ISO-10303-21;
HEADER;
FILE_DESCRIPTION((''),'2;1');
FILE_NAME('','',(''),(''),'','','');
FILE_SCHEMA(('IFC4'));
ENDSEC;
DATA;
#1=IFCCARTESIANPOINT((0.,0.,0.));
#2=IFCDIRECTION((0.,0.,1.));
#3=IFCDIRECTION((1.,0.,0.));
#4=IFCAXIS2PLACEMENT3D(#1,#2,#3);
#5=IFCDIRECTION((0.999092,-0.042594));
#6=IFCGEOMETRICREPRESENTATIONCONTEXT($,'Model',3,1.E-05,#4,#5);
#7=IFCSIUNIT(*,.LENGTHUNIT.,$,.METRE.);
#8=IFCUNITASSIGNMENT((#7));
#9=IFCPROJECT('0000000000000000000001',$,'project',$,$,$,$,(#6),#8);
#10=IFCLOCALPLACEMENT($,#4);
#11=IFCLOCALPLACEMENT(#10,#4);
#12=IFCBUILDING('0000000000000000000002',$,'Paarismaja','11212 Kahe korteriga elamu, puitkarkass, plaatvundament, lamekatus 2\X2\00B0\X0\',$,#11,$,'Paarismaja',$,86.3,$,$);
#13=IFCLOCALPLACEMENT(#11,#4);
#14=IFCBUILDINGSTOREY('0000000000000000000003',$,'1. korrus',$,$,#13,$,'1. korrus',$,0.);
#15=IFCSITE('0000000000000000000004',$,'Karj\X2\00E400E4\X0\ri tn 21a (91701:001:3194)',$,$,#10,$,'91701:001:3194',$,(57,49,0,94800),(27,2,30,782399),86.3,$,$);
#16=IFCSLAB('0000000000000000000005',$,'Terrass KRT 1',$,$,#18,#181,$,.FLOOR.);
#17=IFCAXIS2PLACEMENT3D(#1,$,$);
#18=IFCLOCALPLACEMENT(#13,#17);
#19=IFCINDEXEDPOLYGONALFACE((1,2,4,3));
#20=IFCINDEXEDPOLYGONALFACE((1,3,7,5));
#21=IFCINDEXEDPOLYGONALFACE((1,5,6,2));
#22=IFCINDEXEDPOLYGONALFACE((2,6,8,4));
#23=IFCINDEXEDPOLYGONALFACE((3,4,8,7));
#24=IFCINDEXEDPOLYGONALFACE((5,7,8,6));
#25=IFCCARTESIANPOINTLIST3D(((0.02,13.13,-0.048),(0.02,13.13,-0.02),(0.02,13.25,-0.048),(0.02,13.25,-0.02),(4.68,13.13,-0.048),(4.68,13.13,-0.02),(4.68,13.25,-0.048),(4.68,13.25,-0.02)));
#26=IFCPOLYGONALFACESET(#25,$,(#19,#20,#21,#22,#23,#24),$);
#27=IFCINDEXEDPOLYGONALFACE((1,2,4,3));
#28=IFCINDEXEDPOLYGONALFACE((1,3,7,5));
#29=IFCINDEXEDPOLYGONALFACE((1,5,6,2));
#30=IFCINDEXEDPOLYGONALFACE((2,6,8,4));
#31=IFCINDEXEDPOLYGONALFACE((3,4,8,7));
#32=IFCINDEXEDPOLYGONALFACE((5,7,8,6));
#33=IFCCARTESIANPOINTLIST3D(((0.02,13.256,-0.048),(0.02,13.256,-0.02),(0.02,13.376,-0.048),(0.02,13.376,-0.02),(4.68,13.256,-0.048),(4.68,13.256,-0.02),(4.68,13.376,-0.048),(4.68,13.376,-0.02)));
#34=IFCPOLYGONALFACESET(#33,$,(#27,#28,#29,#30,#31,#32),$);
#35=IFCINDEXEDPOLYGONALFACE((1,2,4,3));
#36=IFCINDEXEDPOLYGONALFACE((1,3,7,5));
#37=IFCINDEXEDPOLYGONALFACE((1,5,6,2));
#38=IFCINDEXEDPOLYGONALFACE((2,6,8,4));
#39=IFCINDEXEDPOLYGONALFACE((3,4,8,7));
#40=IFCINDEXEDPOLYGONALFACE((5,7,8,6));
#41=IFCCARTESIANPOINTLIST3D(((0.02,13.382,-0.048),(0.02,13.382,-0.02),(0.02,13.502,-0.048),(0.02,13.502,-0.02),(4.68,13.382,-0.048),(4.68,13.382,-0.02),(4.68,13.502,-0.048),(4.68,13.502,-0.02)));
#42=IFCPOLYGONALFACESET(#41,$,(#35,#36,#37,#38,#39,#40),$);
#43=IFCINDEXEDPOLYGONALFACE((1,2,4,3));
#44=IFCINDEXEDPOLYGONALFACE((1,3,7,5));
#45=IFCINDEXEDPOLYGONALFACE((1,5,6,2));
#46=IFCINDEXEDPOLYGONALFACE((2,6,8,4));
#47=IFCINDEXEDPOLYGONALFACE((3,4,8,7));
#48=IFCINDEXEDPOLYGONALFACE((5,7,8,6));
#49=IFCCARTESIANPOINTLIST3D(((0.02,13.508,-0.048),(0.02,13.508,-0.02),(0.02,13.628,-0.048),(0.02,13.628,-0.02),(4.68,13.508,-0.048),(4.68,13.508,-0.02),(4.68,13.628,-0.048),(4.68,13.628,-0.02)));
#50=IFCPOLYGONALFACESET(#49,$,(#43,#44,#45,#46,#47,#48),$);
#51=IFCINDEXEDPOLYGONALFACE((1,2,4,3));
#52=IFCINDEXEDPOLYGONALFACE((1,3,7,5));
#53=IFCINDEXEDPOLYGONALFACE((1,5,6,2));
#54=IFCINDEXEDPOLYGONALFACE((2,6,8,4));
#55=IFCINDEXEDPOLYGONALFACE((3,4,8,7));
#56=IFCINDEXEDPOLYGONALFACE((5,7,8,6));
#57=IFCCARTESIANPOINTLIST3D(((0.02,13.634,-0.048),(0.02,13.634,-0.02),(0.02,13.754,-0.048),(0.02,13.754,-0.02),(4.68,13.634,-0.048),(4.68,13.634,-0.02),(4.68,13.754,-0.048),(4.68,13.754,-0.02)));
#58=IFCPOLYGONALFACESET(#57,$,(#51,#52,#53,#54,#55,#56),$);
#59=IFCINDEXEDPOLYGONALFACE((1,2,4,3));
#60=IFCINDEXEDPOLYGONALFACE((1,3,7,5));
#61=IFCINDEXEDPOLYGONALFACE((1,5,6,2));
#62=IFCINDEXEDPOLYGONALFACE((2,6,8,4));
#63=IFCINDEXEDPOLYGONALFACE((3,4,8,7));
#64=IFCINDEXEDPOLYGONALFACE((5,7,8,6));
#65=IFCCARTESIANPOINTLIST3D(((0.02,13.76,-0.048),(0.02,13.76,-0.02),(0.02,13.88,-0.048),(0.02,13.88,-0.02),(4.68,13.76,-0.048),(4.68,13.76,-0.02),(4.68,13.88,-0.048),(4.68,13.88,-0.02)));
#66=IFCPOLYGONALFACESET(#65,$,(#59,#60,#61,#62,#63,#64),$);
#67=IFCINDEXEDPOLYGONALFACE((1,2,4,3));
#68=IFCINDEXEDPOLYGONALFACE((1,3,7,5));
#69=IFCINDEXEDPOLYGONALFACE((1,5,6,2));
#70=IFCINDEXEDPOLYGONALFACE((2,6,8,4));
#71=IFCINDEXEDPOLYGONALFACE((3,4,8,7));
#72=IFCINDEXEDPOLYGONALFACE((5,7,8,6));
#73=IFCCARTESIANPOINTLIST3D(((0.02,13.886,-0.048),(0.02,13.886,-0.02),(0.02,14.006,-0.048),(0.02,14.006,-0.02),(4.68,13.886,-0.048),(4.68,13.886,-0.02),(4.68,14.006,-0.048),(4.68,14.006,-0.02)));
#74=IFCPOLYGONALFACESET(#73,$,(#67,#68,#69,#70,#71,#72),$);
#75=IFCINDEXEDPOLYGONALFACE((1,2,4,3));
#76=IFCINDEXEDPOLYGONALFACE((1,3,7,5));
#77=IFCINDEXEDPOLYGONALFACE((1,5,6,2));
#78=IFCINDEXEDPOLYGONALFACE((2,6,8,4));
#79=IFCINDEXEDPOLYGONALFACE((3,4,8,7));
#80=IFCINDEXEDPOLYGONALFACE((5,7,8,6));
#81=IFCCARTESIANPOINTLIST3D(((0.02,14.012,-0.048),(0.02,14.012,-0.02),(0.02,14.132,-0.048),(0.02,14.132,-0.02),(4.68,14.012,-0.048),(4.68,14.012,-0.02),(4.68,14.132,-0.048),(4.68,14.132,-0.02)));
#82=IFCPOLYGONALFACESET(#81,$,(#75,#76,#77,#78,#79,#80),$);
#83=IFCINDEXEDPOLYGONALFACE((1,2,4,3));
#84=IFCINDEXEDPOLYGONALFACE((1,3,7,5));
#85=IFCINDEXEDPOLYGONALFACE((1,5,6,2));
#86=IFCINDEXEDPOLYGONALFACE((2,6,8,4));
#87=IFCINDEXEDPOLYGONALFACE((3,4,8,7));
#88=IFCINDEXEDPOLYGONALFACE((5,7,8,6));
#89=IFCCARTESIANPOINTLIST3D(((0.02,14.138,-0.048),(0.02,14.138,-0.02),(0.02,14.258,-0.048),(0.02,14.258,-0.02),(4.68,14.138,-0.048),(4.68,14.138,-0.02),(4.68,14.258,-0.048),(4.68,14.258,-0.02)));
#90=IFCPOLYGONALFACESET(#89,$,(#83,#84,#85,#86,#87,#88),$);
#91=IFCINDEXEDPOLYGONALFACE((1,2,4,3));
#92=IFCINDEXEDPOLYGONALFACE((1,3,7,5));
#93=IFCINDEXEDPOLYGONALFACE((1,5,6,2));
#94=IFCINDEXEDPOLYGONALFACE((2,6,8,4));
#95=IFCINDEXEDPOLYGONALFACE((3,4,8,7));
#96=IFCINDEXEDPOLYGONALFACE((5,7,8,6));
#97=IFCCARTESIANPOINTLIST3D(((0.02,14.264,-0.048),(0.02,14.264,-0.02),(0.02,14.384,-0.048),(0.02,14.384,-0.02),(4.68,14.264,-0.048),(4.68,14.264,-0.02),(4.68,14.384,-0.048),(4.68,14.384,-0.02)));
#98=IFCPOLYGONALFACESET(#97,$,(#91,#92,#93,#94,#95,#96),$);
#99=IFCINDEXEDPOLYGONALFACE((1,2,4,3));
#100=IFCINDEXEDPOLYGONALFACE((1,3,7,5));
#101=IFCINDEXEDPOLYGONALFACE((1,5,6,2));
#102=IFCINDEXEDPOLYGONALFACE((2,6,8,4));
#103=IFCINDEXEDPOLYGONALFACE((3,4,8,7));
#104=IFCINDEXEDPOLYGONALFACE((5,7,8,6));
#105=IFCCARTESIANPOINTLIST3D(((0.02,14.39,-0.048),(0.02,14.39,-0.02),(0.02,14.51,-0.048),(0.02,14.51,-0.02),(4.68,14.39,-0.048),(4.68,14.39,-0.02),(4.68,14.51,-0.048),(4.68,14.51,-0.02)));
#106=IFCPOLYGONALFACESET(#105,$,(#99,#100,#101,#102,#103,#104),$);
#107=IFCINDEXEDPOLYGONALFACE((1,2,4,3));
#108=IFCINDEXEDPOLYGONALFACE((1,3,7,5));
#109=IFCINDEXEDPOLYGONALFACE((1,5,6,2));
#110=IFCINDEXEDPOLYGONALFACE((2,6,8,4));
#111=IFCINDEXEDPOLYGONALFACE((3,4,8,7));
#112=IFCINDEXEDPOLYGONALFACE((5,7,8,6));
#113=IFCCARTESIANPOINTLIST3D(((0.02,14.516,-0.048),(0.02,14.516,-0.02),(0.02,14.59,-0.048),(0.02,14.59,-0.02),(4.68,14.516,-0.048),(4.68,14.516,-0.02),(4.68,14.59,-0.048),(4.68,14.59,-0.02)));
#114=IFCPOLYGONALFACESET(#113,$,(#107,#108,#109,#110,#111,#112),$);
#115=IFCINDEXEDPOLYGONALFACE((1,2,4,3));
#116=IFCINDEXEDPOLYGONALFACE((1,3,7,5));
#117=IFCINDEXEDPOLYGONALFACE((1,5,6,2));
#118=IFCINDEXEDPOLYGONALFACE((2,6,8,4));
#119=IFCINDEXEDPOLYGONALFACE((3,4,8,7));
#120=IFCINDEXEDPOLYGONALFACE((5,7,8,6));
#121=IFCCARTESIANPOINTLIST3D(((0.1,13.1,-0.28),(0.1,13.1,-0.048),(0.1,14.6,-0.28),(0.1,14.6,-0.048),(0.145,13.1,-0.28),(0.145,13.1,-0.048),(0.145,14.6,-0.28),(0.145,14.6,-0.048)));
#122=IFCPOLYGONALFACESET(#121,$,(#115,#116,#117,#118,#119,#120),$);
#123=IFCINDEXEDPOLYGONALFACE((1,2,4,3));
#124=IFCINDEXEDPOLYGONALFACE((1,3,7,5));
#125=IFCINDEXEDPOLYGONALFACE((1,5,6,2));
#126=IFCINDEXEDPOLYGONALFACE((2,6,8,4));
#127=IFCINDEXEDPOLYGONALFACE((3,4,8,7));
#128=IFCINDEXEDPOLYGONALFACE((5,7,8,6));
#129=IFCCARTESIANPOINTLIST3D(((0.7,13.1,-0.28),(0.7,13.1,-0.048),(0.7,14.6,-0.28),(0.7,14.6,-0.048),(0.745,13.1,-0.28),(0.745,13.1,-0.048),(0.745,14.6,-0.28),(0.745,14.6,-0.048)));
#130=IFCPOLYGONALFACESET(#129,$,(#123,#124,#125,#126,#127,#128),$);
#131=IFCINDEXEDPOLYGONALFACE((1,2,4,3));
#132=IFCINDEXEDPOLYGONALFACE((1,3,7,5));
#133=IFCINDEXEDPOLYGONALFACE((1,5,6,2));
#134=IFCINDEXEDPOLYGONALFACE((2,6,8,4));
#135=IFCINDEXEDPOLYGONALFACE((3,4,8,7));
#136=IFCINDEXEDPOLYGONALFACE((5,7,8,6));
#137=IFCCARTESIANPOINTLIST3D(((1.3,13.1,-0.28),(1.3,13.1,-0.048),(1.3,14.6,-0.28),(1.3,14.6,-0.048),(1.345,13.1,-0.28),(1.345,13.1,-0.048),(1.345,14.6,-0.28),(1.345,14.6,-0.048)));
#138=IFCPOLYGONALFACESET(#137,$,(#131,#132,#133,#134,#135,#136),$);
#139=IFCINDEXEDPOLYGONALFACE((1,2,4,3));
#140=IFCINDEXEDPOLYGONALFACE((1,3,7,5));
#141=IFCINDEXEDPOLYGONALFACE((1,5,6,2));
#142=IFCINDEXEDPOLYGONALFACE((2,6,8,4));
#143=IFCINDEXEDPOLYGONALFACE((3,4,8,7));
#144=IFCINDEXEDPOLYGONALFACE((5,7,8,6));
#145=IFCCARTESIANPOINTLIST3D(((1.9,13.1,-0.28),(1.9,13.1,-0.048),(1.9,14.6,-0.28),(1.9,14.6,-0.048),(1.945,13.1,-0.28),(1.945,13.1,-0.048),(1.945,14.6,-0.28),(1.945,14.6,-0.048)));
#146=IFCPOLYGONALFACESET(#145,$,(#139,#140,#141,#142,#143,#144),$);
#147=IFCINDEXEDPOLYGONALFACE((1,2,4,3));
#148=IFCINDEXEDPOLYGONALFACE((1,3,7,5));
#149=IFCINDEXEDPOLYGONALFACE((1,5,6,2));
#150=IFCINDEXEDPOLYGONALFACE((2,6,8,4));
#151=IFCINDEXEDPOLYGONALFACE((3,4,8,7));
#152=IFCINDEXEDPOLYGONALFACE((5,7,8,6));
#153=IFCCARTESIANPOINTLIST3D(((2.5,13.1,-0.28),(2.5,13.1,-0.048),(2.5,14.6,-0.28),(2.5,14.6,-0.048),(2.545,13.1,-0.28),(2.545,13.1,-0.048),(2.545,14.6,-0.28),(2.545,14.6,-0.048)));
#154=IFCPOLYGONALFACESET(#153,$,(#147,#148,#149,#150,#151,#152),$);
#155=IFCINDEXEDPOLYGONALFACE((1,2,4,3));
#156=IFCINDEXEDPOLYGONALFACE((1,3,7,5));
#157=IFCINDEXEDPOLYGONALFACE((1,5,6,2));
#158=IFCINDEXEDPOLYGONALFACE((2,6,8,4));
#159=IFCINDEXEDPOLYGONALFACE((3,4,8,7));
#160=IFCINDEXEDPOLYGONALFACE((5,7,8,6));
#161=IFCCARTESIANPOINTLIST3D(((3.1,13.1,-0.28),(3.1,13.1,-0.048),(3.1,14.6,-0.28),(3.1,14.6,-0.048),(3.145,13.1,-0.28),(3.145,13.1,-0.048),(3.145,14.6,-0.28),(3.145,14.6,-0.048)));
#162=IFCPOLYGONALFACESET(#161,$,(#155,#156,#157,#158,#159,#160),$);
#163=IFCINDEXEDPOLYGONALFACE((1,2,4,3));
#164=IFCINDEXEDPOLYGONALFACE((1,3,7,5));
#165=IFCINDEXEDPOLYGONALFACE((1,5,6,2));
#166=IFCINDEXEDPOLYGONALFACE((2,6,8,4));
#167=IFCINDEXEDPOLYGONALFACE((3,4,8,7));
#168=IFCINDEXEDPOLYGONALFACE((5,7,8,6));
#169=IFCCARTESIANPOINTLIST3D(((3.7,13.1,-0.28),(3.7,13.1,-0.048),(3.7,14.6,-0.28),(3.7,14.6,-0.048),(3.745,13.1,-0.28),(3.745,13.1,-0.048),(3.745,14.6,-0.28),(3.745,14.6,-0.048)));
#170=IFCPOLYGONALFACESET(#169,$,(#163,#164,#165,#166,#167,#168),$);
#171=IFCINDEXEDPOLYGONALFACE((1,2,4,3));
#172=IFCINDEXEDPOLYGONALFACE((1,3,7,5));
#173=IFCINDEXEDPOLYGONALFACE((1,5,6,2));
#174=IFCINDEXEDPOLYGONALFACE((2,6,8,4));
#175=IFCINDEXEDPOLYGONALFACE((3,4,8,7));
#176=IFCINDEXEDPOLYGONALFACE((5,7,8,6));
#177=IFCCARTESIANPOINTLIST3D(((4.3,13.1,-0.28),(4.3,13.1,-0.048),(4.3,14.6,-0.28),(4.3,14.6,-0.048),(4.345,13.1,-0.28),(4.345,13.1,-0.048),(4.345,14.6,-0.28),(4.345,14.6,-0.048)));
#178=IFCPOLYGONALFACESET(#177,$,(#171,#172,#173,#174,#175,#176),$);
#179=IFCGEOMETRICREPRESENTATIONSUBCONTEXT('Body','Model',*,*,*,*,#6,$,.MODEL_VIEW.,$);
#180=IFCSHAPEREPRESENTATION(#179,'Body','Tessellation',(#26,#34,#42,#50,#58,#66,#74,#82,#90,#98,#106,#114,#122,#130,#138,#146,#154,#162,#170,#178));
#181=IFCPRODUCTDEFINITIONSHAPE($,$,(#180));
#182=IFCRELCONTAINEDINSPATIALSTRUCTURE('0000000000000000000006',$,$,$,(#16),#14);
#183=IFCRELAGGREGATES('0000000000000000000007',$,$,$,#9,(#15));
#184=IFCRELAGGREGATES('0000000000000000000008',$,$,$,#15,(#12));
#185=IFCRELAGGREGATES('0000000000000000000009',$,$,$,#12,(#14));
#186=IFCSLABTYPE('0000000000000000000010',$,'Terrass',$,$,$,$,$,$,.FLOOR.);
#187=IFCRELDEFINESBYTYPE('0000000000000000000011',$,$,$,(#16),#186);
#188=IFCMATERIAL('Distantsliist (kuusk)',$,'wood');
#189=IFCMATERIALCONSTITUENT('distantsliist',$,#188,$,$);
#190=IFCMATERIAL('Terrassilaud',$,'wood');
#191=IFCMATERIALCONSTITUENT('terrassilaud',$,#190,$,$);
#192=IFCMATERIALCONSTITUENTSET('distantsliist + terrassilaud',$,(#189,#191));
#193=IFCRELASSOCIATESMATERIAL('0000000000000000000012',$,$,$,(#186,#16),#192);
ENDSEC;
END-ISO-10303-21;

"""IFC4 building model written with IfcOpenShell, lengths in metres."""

from ifc_helpers import new_model, si_unit, direction, frame, origin_with_axes, place, context, subcontext, project, spatial, indexed_curve, outline, extrude, material, constituent, constituent_set, type_object, element, save


model = new_model("IFC4")

# Units and contexts
model_context = context("Model", 3, precision=1e-05, world=origin_with_axes(), true_north=direction((0.999092, -0.042594)))
body_context = subcontext(model_context, "Body", "Model", "MODEL_VIEW")
ifc_project = project(units=[si_unit("LENGTHUNIT", "METRE")], contexts=[model_context])

# Site, building, storey
site_placement = place(None, origin_with_axes())
site = spatial("IfcSite", under=ifc_project, at=site_placement, Name="Karjääri tn 21a (91701:001:3194)", LongName="91701:001:3194", RefLatitude=(57, 49, 0, 94800), RefLongitude=(27, 2, 30, 782399), RefElevation=86.3)
building_placement = place(site_placement, origin_with_axes())
building = spatial("IfcBuilding", under=site, at=building_placement, Name="Paarismaja", Description="11212 Kahe korteriga elamu, puitkarkass, plaatvundament, lamekatus 2°", LongName="Paarismaja", ElevationOfRefHeight=86.3)
storey_placement = place(building_placement, origin_with_axes())
storey = spatial("IfcBuildingStorey", under=building, at=storey_placement, Name="1. korrus", LongName="1. korrus", Elevation=0.0)

# Slab
ifc_material_1 = material(Name="Distantsliist (kuusk)", Category="wood")
ifc_constituent_1 = constituent(ifc_material_1, Name="distantsliist")
ifc_material_2 = material(Name="Terrassilaud", Category="wood")
ifc_constituent_2 = constituent(ifc_material_2, Name="terrassilaud")
ifc_constituent_set_1 = constituent_set(constituents=[ifc_constituent_1, ifc_constituent_2], Name="distantsliist + terrassilaud")
slab_type_1 = type_object("IfcSlabType", Name="Terrass", PredefinedType="FLOOR", material=ifc_constituent_set_1)
slab_1_placement = place(storey_placement, origin_with_axes())
element("IfcSlab", 1, at=slab_1_placement, inside=storey, type_object=slab_type_1, material=ifc_constituent_set_1, Name="Terrass KRT 1", PredefinedType="FLOOR", context=body_context, shape_type="SweptSolid", body=[
    extrude(outline(indexed_curve([(0.02, 13.13), (4.68, 13.13), (4.68, 13.25), (0.02, 13.25), (0.02, 13.13)], self_intersect=False)), frame((0.0, 0.0, -0.048), z_axis=(0.0, 0.0, 1.0), x_axis=(1.0, 0.0, 0.0)), (0.0, 0.0, 1.0), 0.028),
    extrude(outline(indexed_curve([(0.02, 13.256), (4.68, 13.256), (4.68, 13.376), (0.02, 13.376), (0.02, 13.256)], self_intersect=False)), frame((0.0, 0.0, -0.048), z_axis=(0.0, 0.0, 1.0), x_axis=(1.0, 0.0, 0.0)), (0.0, 0.0, 1.0), 0.028),
    extrude(outline(indexed_curve([(0.02, 13.382), (4.68, 13.382), (4.68, 13.502), (0.02, 13.502), (0.02, 13.382)], self_intersect=False)), frame((0.0, 0.0, -0.048), z_axis=(0.0, 0.0, 1.0), x_axis=(1.0, 0.0, 0.0)), (0.0, 0.0, 1.0), 0.028),
    extrude(outline(indexed_curve([(0.02, 13.508), (4.68, 13.508), (4.68, 13.628), (0.02, 13.628), (0.02, 13.508)], self_intersect=False)), frame((0.0, 0.0, -0.048), z_axis=(0.0, 0.0, 1.0), x_axis=(1.0, 0.0, 0.0)), (0.0, 0.0, 1.0), 0.028),
    extrude(outline(indexed_curve([(0.02, 13.634), (4.68, 13.634), (4.68, 13.754), (0.02, 13.754), (0.02, 13.634)], self_intersect=False)), frame((0.0, 0.0, -0.048), z_axis=(0.0, 0.0, 1.0), x_axis=(1.0, 0.0, 0.0)), (0.0, 0.0, 1.0), 0.028),
    extrude(outline(indexed_curve([(0.02, 13.76), (4.68, 13.76), (4.68, 13.88), (0.02, 13.88), (0.02, 13.76)], self_intersect=False)), frame((0.0, 0.0, -0.048), z_axis=(0.0, 0.0, 1.0), x_axis=(1.0, 0.0, 0.0)), (0.0, 0.0, 1.0), 0.028),
    extrude(outline(indexed_curve([(0.02, 13.886), (4.68, 13.886), (4.68, 14.006), (0.02, 14.006), (0.02, 13.886)], self_intersect=False)), frame((0.0, 0.0, -0.048), z_axis=(0.0, 0.0, 1.0), x_axis=(1.0, 0.0, 0.0)), (0.0, 0.0, 1.0), 0.028),
    extrude(outline(indexed_curve([(0.02, 14.012), (4.68, 14.012), (4.68, 14.132), (0.02, 14.132), (0.02, 14.012)], self_intersect=False)), frame((0.0, 0.0, -0.048), z_axis=(0.0, 0.0, 1.0), x_axis=(1.0, 0.0, 0.0)), (0.0, 0.0, 1.0), 0.028),
    extrude(outline(indexed_curve([(0.02, 14.138), (4.68, 14.138), (4.68, 14.258), (0.02, 14.258), (0.02, 14.138)], self_intersect=False)), frame((0.0, 0.0, -0.048), z_axis=(0.0, 0.0, 1.0), x_axis=(1.0, 0.0, 0.0)), (0.0, 0.0, 1.0), 0.028),
    extrude(outline(indexed_curve([(0.02, 14.264), (4.68, 14.264), (4.68, 14.384), (0.02, 14.384), (0.02, 14.264)], self_intersect=False)), frame((0.0, 0.0, -0.048), z_axis=(0.0, 0.0, 1.0), x_axis=(1.0, 0.0, 0.0)), (0.0, 0.0, 1.0), 0.028),
    extrude(outline(indexed_curve([(0.02, 14.39), (4.68, 14.39), (4.68, 14.51), (0.02, 14.51), (0.02, 14.39)], self_intersect=False)), frame((0.0, 0.0, -0.048), z_axis=(0.0, 0.0, 1.0), x_axis=(1.0, 0.0, 0.0)), (0.0, 0.0, 1.0), 0.028),
    extrude(outline(indexed_curve([(0.02, 14.516), (4.68, 14.516), (4.68, 14.59), (0.02, 14.59), (0.02, 14.516)], self_intersect=False)), frame((0.0, 0.0, -0.048), z_axis=(0.0, 0.0, 1.0), x_axis=(1.0, 0.0, 0.0)), (0.0, 0.0, 1.0), 0.028),
    extrude(outline(indexed_curve([(0.1, 13.1), (0.145, 13.1), (0.145, 14.6), (0.1, 14.6), (0.1, 13.1)], self_intersect=False)), frame((0.0, 0.0, -0.28), z_axis=(0.0, 0.0, 1.0), x_axis=(1.0, 0.0, 0.0)), (0.0, 0.0, 1.0), 0.232),
    extrude(outline(indexed_curve([(0.7, 13.1), (0.745, 13.1), (0.745, 14.6), (0.7, 14.6), (0.7, 13.1)], self_intersect=False)), frame((0.0, 0.0, -0.28), z_axis=(0.0, 0.0, 1.0), x_axis=(1.0, 0.0, 0.0)), (0.0, 0.0, 1.0), 0.232),
    extrude(outline(indexed_curve([(1.3, 13.1), (1.345, 13.1), (1.345, 14.6), (1.3, 14.6), (1.3, 13.1)], self_intersect=False)), frame((0.0, 0.0, -0.28), z_axis=(0.0, 0.0, 1.0), x_axis=(1.0, 0.0, 0.0)), (0.0, 0.0, 1.0), 0.232),
    extrude(outline(indexed_curve([(1.9, 13.1), (1.945, 13.1), (1.945, 14.6), (1.9, 14.6), (1.9, 13.1)], self_intersect=False)), frame((0.0, 0.0, -0.28), z_axis=(0.0, 0.0, 1.0), x_axis=(1.0, 0.0, 0.0)), (0.0, 0.0, 1.0), 0.232),
    extrude(outline(indexed_curve([(2.5, 13.1), (2.545, 13.1), (2.545, 14.6), (2.5, 14.6), (2.5, 13.1)], self_intersect=False)), frame((0.0, 0.0, -0.28), z_axis=(0.0, 0.0, 1.0), x_axis=(1.0, 0.0, 0.0)), (0.0, 0.0, 1.0), 0.232),
    extrude(outline(indexed_curve([(3.1, 13.1), (3.145, 13.1), (3.145, 14.6), (3.1, 14.6), (3.1, 13.1)], self_intersect=False)), frame((0.0, 0.0, -0.28), z_axis=(0.0, 0.0, 1.0), x_axis=(1.0, 0.0, 0.0)), (0.0, 0.0, 1.0), 0.232),
    extrude(outline(indexed_curve([(3.7, 13.1), (3.745, 13.1), (3.745, 14.6), (3.7, 14.6), (3.7, 13.1)], self_intersect=False)), frame((0.0, 0.0, -0.28), z_axis=(0.0, 0.0, 1.0), x_axis=(1.0, 0.0, 0.0)), (0.0, 0.0, 1.0), 0.232),
    extrude(outline(indexed_curve([(4.3, 13.1), (4.345, 13.1), (4.345, 14.6), (4.3, 14.6), (4.3, 13.1)], self_intersect=False)), frame((0.0, 0.0, -0.28), z_axis=(0.0, 0.0, 1.0), x_axis=(1.0, 0.0, 0.0)), (0.0, 0.0, 1.0), 0.232),
])

save(model, "model.ifc")
